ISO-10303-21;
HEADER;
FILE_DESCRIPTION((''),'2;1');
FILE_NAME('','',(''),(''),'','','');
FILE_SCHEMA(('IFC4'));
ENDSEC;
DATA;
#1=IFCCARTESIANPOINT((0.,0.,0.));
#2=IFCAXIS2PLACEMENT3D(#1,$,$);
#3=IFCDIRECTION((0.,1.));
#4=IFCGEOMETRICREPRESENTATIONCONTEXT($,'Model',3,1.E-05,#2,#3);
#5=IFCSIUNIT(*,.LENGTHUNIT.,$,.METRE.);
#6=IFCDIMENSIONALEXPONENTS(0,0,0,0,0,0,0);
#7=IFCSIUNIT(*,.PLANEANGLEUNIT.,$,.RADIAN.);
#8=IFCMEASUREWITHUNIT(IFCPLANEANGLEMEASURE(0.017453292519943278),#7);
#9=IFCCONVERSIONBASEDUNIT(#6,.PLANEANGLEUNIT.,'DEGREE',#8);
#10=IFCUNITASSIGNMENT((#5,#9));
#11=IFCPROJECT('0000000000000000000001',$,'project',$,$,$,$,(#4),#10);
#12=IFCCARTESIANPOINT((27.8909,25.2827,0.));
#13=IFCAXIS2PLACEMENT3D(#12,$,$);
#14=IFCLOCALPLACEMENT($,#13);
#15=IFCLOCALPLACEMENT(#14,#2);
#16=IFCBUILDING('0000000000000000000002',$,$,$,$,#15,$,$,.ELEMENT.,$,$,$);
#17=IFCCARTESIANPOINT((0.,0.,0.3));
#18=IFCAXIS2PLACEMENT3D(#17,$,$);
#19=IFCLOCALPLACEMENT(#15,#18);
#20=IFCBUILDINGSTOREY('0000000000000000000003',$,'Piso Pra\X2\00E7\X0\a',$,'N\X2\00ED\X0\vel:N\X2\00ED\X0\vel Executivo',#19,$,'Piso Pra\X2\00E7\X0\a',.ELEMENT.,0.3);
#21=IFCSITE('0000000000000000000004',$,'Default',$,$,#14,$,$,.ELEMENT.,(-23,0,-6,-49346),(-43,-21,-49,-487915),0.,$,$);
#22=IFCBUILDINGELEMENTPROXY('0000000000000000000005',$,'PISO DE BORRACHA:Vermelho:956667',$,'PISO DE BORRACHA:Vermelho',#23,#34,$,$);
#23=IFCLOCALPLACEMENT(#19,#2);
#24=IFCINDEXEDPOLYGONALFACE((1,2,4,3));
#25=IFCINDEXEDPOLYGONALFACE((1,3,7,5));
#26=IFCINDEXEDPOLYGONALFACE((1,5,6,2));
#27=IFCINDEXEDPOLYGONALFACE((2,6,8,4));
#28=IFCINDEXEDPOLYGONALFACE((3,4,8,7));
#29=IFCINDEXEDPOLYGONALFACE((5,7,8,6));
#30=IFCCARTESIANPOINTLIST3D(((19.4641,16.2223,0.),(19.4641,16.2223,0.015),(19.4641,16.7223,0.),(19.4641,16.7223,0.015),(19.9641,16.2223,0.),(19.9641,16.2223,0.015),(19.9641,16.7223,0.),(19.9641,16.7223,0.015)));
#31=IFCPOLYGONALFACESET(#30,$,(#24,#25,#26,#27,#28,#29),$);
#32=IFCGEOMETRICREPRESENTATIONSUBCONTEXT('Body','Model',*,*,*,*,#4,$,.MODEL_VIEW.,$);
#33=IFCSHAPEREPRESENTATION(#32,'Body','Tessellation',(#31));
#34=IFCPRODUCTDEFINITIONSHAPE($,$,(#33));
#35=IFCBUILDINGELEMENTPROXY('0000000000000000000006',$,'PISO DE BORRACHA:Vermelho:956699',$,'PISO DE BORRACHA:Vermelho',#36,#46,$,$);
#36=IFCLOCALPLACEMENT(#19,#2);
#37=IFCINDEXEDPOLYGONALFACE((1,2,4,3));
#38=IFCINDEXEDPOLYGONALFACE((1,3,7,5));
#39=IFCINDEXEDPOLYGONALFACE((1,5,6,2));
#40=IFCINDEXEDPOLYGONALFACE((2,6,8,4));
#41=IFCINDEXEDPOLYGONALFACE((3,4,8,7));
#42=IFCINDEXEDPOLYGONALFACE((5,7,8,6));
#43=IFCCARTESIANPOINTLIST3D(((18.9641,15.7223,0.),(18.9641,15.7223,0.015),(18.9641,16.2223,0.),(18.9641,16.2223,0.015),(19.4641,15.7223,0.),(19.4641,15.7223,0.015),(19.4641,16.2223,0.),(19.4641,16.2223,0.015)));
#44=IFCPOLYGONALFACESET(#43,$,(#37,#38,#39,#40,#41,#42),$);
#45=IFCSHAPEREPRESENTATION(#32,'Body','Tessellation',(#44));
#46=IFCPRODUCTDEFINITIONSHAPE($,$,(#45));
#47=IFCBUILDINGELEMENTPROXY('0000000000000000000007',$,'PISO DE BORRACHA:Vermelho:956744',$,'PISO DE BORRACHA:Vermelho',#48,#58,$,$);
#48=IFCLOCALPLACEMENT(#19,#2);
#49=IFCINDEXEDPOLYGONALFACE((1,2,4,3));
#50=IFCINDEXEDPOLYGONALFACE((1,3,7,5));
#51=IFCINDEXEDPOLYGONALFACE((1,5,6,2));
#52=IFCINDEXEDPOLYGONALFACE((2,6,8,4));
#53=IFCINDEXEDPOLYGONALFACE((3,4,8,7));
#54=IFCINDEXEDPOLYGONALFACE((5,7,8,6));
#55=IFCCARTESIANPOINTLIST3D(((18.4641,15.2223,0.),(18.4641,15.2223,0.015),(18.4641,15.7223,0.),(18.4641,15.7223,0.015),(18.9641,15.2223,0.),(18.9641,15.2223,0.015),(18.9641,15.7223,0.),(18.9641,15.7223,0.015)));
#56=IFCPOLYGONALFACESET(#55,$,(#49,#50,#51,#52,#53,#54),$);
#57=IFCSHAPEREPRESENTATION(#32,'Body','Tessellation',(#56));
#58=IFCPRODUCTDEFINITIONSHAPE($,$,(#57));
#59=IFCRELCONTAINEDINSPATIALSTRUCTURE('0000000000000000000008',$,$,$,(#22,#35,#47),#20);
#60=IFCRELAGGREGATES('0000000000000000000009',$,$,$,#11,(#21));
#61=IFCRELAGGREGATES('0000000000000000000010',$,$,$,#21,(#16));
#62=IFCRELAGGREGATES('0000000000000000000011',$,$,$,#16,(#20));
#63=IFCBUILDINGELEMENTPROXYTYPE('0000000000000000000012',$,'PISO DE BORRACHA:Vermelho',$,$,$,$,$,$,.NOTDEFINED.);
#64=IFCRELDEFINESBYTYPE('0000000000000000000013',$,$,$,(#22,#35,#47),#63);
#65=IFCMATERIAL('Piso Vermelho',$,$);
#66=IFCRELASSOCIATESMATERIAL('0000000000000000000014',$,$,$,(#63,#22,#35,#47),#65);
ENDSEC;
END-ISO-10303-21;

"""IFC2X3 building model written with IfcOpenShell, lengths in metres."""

from ifc_helpers import new_model, entity, si_unit, converted_unit, direction, frame, origin, origin_2d_with_axis, place, context, subcontext, project, spatial, rectangle, extrude, source, transform, mapped, material, type_object, type_shapes, element, save


model = new_model("IFC2X3")

# Units and contexts
model_context = context("Model", 3, precision=1e-05, world=origin(), true_north=direction((0.0, 1.0)))
body_context = subcontext(model_context, "Body", "Model", "MODEL_VIEW")
ifc_project = project(units=[si_unit("LENGTHUNIT", "METRE"), converted_unit("PLANEANGLEUNIT", "DEGREE", entity("IfcPlaneAngleMeasure", 0.017453292519943278), si_unit("PLANEANGLEUNIT", "RADIAN"), dimensions=[0, 0, 0, 0, 0, 0, 0])], contexts=[model_context])

# Site, building, storey
site_placement = place(None, frame((27.8909, 25.2827, 0.0)))
site = spatial("IfcSite", under=ifc_project, at=site_placement, Name="Default", CompositionType="ELEMENT", RefLatitude=(-23, 0, -6, -49346), RefLongitude=(-43, -21, -49, -487915), RefElevation=0.0)
building_placement = place(site_placement, origin())
building = spatial("IfcBuilding", under=site, at=building_placement, CompositionType="ELEMENT")
storey_placement = place(building_placement, frame((0.0, 0.0, 0.3)))
storey = spatial("IfcBuildingStorey", under=building, at=storey_placement, Name="Piso Praça", ObjectType="Nível:Nível Executivo", LongName="Piso Praça", CompositionType="ELEMENT", Elevation=0.3)

# Building element proxies
ifc_material_1 = material(Name="Piso Vermelho")
building_element_proxy_type_1 = type_object("IfcBuildingElementProxyType", Name="PISO DE BORRACHA:Vermelho", PredefinedType="NOTDEFINED", material=ifc_material_1)
shared_shape_1 = source(origin(), body_context, "Body", "SweptSolid", [
    extrude(rectangle(XDim=0.5, YDim=0.5, at=origin_2d_with_axis()), frame((0.25, 0.25, 0.0), z_axis=(0.0, 0.0, 1.0), x_axis=(-1.0, 0.0, 0.0)), (0.0, 0.0, 1.0), 0.015),
])
type_shapes(building_element_proxy_type_1, [shared_shape_1])
for number, where, name in (
    (1, (19.4641, 16.2223, 0.0), "PISO DE BORRACHA:Vermelho:956667"),
    (2, (18.9641, 15.7223, 0.0), "PISO DE BORRACHA:Vermelho:956699"),
    (3, (18.4641, 15.2223, 0.0), "PISO DE BORRACHA:Vermelho:956744"),
):
    element("IfcBuildingElementProxy", number, at=place(storey_placement, frame(where)), inside=storey, type_object=building_element_proxy_type_1, material=ifc_material_1, Name=name, ObjectType="PISO DE BORRACHA:Vermelho", context=body_context, shape_type="MappedRepresentation", body=[
        mapped(shared_shape_1, transform((0.0, 0.0, 0.0), scale=1.0)),
    ])

save(model, "model.ifc")
